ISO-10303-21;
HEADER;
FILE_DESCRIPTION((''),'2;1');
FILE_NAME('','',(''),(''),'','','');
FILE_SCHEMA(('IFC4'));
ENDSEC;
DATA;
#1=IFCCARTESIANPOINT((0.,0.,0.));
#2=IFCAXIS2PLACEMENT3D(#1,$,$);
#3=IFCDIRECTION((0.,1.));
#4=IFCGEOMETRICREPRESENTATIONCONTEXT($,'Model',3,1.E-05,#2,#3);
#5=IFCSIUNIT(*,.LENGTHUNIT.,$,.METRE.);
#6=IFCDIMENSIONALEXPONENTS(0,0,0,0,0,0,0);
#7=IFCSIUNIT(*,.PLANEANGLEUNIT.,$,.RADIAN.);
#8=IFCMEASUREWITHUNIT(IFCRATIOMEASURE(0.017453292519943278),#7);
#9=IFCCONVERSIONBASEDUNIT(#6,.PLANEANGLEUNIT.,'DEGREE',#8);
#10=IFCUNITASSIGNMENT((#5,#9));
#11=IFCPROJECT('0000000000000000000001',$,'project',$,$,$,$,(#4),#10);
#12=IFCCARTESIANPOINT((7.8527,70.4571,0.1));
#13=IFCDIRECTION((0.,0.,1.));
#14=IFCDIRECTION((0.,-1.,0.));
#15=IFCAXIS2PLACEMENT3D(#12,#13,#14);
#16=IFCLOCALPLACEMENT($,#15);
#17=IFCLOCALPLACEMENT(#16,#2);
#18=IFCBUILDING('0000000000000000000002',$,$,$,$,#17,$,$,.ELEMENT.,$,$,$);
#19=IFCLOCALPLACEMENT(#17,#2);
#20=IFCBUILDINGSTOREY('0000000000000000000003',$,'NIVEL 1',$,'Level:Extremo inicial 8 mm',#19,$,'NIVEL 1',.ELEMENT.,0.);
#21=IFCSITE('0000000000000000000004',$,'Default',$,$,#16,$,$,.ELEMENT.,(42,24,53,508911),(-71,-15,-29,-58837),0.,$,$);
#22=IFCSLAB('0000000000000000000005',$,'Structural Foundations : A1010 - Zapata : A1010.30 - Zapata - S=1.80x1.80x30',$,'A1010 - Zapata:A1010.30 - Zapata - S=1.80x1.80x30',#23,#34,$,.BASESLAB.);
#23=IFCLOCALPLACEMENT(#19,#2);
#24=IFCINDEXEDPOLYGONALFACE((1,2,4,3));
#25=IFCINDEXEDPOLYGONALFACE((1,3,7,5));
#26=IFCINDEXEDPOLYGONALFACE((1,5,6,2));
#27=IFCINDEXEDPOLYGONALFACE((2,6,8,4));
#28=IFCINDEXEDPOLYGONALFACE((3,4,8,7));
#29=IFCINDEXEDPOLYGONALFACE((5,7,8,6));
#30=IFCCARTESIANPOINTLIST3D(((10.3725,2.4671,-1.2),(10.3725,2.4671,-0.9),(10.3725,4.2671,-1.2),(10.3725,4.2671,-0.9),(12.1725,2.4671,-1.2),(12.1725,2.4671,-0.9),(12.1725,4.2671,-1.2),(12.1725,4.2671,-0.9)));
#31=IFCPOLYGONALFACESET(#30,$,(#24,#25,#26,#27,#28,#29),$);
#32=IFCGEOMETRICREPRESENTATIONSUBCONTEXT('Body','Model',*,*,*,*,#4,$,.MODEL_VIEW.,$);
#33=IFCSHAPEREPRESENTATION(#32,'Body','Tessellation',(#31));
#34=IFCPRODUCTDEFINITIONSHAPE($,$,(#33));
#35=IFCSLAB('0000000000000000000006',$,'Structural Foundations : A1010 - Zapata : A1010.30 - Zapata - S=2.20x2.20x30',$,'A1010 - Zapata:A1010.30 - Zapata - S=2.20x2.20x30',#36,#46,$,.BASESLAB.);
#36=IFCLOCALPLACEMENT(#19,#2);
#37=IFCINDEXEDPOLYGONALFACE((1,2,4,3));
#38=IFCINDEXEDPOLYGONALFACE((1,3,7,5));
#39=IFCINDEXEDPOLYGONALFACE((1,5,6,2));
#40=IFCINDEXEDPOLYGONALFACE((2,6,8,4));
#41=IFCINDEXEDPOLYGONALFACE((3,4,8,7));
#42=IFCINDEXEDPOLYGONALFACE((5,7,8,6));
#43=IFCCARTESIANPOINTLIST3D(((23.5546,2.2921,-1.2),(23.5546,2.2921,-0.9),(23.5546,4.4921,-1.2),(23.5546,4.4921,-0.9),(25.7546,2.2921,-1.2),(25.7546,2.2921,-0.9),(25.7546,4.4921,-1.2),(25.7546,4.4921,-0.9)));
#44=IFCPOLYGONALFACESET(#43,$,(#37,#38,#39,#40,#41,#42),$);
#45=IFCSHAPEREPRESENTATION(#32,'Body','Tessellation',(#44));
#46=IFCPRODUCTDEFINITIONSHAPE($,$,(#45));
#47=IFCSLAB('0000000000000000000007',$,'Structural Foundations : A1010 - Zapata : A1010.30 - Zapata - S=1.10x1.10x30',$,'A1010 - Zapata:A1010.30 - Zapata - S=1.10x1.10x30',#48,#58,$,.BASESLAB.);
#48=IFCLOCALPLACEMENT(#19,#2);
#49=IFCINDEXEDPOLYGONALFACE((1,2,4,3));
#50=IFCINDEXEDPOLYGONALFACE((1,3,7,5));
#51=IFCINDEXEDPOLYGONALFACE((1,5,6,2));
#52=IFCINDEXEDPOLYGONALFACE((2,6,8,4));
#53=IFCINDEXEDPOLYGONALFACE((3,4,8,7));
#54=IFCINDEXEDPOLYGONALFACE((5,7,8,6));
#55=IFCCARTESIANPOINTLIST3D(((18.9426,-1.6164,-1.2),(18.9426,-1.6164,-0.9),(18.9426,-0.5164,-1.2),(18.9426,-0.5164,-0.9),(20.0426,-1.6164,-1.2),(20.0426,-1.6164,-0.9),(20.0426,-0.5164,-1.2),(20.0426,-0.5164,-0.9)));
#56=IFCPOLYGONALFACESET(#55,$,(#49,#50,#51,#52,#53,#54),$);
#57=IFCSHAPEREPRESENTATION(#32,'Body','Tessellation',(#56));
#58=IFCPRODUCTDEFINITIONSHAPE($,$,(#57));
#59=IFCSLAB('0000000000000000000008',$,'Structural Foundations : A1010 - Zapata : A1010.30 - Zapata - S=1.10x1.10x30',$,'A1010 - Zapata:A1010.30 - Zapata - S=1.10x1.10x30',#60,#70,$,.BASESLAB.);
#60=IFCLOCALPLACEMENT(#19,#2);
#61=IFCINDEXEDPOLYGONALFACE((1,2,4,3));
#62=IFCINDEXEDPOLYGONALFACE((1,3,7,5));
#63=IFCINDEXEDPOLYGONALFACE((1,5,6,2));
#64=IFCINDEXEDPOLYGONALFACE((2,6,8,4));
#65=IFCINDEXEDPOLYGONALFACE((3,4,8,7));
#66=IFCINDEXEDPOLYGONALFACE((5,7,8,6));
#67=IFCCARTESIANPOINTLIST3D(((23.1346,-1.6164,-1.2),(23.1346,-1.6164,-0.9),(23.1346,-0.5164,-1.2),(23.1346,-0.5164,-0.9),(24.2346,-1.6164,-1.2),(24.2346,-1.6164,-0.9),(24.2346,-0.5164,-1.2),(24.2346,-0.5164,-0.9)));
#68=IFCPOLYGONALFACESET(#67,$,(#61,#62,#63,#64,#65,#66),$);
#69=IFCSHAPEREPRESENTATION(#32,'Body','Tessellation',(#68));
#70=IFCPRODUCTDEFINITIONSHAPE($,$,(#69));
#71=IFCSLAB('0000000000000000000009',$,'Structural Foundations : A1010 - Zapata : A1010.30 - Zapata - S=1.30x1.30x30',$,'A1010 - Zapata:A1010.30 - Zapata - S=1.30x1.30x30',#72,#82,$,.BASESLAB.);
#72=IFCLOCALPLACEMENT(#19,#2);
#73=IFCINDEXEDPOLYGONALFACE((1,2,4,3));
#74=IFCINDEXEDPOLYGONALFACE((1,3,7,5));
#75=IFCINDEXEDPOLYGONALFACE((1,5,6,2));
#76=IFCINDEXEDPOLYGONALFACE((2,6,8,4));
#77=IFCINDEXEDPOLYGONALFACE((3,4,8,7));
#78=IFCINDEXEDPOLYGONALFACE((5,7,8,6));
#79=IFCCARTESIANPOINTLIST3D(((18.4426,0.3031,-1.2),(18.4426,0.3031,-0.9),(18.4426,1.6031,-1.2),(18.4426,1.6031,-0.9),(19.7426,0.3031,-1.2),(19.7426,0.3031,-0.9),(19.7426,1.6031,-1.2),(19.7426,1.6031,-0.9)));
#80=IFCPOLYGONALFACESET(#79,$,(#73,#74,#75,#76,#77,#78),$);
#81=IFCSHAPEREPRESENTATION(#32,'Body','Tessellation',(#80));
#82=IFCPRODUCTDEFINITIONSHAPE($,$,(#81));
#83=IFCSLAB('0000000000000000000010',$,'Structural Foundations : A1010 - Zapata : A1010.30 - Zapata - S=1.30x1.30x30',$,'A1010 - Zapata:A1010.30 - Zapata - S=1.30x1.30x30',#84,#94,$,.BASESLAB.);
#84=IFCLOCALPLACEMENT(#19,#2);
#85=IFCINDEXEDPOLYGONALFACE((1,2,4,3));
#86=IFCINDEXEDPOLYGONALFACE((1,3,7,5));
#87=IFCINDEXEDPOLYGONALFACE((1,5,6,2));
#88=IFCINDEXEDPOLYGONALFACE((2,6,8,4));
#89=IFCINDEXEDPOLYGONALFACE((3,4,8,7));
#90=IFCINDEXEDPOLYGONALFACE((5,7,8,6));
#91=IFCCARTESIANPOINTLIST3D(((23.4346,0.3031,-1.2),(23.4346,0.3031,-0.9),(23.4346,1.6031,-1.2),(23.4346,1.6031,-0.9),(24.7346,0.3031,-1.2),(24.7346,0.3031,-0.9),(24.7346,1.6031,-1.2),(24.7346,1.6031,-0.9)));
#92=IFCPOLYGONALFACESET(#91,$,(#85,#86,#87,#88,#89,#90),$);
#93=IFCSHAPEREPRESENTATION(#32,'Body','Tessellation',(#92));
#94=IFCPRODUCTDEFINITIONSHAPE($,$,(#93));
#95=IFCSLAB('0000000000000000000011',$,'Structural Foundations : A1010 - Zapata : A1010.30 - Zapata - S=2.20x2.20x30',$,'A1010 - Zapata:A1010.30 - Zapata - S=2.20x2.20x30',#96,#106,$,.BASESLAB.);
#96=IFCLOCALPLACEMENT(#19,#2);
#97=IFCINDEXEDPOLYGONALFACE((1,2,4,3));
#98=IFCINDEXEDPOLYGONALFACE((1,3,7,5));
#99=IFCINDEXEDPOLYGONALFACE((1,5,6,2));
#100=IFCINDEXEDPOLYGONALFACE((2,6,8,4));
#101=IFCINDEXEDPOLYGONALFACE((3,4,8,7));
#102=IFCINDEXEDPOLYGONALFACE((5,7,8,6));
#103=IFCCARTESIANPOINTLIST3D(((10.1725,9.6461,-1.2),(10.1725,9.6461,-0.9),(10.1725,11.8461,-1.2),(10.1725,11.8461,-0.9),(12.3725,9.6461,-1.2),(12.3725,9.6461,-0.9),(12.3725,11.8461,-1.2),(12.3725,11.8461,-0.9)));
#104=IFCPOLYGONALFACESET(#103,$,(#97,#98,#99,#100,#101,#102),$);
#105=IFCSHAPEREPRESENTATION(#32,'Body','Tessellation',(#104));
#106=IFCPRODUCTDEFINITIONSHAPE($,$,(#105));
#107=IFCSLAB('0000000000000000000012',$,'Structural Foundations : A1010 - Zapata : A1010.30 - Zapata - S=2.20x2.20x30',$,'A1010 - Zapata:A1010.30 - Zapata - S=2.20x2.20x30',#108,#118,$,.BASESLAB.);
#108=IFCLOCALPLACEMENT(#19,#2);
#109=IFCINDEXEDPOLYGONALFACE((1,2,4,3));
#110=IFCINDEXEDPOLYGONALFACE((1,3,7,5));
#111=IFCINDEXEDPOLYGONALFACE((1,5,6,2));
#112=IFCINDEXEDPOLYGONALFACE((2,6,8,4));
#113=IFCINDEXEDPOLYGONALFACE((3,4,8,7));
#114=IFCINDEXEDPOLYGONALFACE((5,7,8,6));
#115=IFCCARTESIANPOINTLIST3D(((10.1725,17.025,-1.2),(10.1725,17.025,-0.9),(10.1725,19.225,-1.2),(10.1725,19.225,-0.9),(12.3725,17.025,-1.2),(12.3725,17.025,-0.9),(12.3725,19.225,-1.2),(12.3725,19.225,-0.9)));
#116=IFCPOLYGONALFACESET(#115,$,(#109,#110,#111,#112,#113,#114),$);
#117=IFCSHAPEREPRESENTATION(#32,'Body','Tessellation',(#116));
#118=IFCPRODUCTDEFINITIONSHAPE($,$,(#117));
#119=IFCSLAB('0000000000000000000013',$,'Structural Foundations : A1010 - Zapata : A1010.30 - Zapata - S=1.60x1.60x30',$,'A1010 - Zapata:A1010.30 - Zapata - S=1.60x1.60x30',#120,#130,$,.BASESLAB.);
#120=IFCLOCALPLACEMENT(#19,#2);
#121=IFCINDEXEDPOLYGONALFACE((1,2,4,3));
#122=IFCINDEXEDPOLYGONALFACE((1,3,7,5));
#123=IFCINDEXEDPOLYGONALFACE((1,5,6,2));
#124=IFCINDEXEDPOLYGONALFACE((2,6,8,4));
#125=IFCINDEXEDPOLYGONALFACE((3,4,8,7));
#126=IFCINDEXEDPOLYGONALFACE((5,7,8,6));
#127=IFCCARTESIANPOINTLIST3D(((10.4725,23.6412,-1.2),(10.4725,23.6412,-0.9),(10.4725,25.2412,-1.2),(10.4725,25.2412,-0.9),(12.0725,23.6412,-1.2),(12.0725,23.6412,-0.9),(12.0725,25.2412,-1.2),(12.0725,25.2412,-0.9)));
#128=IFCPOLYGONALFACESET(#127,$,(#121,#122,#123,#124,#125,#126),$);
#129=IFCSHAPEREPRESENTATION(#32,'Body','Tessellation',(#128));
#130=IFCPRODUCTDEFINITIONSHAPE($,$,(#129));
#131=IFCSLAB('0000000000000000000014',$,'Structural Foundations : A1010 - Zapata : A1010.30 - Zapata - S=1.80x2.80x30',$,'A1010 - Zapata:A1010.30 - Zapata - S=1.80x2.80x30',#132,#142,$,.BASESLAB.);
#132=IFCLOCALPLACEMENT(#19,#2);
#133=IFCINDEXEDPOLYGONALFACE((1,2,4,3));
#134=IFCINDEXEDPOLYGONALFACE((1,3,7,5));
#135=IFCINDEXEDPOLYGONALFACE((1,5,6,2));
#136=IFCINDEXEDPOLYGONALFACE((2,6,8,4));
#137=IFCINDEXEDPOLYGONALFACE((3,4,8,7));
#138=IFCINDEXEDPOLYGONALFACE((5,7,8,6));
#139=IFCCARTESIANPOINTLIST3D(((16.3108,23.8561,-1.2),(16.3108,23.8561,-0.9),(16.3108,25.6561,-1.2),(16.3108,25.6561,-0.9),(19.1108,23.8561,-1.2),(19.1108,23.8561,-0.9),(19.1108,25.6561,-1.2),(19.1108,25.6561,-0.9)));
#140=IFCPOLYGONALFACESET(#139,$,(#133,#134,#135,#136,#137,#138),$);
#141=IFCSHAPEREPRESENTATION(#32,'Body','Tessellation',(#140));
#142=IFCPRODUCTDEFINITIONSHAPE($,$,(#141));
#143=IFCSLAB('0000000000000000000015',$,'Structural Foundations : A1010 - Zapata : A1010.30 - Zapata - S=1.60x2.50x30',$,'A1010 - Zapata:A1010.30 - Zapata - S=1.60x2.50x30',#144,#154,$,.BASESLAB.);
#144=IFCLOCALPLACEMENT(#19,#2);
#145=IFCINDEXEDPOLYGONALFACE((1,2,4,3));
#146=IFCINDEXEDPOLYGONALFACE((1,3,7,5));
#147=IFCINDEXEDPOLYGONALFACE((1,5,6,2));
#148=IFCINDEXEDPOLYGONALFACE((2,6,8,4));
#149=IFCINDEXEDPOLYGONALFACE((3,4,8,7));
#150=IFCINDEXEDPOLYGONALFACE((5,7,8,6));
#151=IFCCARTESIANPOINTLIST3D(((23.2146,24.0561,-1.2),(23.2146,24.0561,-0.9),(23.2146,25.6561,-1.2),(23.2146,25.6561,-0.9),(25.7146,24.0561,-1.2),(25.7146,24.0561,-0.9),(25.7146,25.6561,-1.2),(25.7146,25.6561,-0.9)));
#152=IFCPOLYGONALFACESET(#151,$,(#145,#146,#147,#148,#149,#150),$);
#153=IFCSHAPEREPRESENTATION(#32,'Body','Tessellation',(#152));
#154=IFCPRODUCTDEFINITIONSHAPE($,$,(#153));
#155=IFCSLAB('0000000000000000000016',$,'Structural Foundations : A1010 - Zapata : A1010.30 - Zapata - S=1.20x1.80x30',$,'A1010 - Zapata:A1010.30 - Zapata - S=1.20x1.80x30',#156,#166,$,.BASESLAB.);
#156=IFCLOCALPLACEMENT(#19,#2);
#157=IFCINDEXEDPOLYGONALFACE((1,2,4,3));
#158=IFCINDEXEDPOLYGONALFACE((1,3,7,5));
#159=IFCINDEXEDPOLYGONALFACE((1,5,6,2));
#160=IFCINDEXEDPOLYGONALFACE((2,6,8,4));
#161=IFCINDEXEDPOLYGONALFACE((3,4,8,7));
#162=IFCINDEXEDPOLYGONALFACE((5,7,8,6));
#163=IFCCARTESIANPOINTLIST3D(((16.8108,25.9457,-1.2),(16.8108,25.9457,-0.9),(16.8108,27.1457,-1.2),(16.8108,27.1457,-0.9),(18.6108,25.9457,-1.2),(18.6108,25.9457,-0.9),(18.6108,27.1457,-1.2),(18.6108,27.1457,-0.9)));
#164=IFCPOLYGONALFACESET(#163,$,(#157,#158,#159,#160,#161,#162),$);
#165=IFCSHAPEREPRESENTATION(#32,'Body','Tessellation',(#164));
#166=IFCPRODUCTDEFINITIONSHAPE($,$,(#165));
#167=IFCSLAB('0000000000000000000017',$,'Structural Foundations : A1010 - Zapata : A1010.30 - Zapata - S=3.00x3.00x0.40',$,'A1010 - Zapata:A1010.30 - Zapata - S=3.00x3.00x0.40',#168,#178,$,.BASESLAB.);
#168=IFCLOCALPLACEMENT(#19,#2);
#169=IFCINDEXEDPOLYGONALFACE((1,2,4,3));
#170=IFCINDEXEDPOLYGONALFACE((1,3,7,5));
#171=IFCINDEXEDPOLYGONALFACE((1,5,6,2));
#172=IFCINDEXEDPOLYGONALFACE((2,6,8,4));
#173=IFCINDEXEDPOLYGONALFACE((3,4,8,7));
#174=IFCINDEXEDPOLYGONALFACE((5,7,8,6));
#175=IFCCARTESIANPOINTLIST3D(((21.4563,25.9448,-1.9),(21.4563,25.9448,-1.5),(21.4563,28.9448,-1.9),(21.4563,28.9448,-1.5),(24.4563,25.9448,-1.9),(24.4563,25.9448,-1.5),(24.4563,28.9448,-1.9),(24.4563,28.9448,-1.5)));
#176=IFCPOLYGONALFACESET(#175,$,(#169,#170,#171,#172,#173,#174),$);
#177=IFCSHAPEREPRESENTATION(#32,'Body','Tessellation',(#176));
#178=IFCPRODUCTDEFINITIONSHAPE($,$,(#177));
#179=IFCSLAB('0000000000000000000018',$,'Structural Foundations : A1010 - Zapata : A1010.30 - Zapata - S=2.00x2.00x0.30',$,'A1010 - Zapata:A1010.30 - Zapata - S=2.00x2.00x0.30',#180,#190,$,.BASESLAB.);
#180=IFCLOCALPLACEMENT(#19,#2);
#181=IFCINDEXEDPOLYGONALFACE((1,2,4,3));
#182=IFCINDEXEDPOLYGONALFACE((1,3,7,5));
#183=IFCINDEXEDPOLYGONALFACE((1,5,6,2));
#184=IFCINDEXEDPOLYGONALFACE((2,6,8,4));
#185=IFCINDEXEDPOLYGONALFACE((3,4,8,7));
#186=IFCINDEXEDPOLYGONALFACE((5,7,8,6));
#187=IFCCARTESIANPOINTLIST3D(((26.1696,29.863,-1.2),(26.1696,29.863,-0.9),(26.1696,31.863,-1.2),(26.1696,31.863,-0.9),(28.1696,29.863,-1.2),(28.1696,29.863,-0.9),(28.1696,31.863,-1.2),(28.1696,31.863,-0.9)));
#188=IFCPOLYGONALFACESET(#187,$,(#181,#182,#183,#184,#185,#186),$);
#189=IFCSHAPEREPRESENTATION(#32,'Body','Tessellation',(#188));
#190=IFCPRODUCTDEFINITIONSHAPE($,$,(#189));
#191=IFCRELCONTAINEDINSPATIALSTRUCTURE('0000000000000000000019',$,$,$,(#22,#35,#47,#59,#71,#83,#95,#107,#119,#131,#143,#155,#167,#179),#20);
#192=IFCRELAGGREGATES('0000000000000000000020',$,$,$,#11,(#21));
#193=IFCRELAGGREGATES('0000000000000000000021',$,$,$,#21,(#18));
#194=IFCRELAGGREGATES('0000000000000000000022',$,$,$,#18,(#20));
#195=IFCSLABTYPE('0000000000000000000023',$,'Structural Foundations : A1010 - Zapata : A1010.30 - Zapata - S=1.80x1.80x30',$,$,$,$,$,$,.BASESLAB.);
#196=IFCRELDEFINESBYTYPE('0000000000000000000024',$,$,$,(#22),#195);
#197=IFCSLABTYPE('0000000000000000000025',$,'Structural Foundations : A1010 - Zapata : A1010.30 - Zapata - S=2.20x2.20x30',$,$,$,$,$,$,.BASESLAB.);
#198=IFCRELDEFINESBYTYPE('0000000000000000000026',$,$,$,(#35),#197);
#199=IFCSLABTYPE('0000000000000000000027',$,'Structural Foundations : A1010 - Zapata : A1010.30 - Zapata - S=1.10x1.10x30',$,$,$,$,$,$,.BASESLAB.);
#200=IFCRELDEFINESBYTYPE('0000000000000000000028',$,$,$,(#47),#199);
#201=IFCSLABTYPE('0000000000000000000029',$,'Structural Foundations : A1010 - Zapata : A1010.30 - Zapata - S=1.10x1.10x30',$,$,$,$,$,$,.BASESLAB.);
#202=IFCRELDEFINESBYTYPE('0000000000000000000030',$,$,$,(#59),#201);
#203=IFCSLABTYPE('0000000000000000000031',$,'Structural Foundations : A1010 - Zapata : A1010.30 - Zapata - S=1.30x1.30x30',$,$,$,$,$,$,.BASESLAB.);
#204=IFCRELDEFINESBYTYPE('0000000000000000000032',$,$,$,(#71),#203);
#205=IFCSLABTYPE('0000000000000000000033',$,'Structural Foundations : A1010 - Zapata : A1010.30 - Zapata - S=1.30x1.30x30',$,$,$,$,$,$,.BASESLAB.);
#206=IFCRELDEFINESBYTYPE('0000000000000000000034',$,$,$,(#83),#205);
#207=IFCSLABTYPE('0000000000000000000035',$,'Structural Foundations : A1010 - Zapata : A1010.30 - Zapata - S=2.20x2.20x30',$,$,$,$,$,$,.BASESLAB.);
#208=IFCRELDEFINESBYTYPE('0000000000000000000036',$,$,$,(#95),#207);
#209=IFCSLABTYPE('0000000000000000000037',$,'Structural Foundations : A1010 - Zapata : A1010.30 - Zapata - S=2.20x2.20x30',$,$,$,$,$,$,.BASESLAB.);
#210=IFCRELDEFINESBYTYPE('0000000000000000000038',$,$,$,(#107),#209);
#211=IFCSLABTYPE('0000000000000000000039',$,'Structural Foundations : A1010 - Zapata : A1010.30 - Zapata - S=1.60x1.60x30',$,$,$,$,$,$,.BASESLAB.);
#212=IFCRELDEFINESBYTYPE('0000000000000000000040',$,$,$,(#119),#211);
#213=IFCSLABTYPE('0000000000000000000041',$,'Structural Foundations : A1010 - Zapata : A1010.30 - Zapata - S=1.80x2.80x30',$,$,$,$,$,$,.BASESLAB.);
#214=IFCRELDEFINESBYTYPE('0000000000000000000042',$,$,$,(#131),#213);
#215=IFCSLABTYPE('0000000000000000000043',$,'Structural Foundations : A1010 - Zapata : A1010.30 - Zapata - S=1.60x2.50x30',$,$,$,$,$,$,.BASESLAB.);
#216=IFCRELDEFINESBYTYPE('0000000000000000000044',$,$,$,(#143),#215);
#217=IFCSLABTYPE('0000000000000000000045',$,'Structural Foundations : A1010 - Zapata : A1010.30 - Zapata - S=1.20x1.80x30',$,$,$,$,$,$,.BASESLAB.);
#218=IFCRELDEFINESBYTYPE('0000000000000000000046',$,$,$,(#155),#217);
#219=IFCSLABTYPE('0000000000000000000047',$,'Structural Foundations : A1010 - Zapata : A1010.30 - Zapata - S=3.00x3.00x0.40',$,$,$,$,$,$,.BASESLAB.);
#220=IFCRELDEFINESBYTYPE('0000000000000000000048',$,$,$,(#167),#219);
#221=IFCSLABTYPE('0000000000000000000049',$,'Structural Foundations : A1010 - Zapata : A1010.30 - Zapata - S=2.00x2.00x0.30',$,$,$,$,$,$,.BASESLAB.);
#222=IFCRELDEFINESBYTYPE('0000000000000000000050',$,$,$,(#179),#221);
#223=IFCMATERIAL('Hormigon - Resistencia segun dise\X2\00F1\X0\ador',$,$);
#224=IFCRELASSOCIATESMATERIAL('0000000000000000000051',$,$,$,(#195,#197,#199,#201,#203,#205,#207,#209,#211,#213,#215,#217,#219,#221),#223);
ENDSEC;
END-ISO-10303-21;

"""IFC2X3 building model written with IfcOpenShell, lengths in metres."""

from ifc_helpers import new_model, entity, si_unit, converted_unit, direction, frame, frame_2d, origin, origin_2d_with_axis, place, context, subcontext, project, spatial, rectangle, extrude, material, type_object, element, save


model = new_model("IFC2X3")

# Units and contexts
model_context = context("Model", 3, precision=1e-05, world=origin(), true_north=direction((0.0, 1.0)))
body_context = subcontext(model_context, "Body", "Model", "MODEL_VIEW")
ifc_project = project(units=[si_unit("LENGTHUNIT", "METRE"), converted_unit("PLANEANGLEUNIT", "DEGREE", entity("IfcRatioMeasure", 0.017453292519943278), si_unit("PLANEANGLEUNIT", "RADIAN"), dimensions=[0, 0, 0, 0, 0, 0, 0])], contexts=[model_context])

# Site, building, storey
site_placement = place(None, frame((7.8527, 70.4571, 0.1), z_axis=(0.0, 0.0, 1.0), x_axis=(0.0, -1.0, 0.0)))
site = spatial("IfcSite", under=ifc_project, at=site_placement, Name="Default", CompositionType="ELEMENT", RefLatitude=(42, 24, 53, 508911), RefLongitude=(-71, -15, -29, -58837), RefElevation=0.0)
building_placement = place(site_placement, origin())
building = spatial("IfcBuilding", under=site, at=building_placement, CompositionType="ELEMENT")
storey_placement = place(building_placement, origin())
storey = spatial("IfcBuildingStorey", under=building, at=storey_placement, Name="NIVEL 1", ObjectType="Level:Extremo inicial 8 mm", LongName="NIVEL 1", CompositionType="ELEMENT", Elevation=0.0)

# Slabs
ifc_material = material(Name="Hormigon - Resistencia segun diseñador")
slab_type_1 = type_object("IfcSlabType", Name="Structural Foundations : A1010 - Zapata : A1010.30 - Zapata - S=1.80x1.80x30", PredefinedType="BASESLAB", material=ifc_material)
slab_1_placement = place(storey_placement, origin())
element("IfcSlab", 1, at=slab_1_placement, inside=storey, type_object=slab_type_1, Name="Structural Foundations : A1010 - Zapata : A1010.30 - Zapata - S=1.80x1.80x30", ObjectType="A1010 - Zapata:A1010.30 - Zapata - S=1.80x1.80x30", PredefinedType="BASESLAB", context=body_context, shape_type="SweptSolid", body=[
    extrude(rectangle(XDim=1.8, YDim=1.8, at=frame_2d((0.0, 0.0), x_axis=(1.0, 0.0))), frame((11.2725, 3.3671, -1.2), z_axis=(0.0, 0.0, 1.0), x_axis=(-1.0, 0.0, 0.0)), (0.0, 0.0, 1.0), 0.3),
])
slab_type_2 = type_object("IfcSlabType", Name="Structural Foundations : A1010 - Zapata : A1010.30 - Zapata - S=2.20x2.20x30", PredefinedType="BASESLAB", material=ifc_material)
slab_2_placement = place(storey_placement, origin())
element("IfcSlab", 2, at=slab_2_placement, inside=storey, type_object=slab_type_2, Name="Structural Foundations : A1010 - Zapata : A1010.30 - Zapata - S=2.20x2.20x30", ObjectType="A1010 - Zapata:A1010.30 - Zapata - S=2.20x2.20x30", PredefinedType="BASESLAB", context=body_context, shape_type="SweptSolid", body=[
    extrude(rectangle(XDim=2.2, YDim=2.2, at=frame_2d((0.0, 0.0), x_axis=(1.0, 0.0))), frame((24.6546, 3.3921, -1.2), z_axis=(0.0, 0.0, 1.0), x_axis=(-1.0, 0.0, 0.0)), (0.0, 0.0, 1.0), 0.3),
])
slab_type_3 = type_object("IfcSlabType", Name="Structural Foundations : A1010 - Zapata : A1010.30 - Zapata - S=1.10x1.10x30", PredefinedType="BASESLAB", material=ifc_material)
slab_3_placement = place(storey_placement, origin())
element("IfcSlab", 3, at=slab_3_placement, inside=storey, type_object=slab_type_3, Name="Structural Foundations : A1010 - Zapata : A1010.30 - Zapata - S=1.10x1.10x30", ObjectType="A1010 - Zapata:A1010.30 - Zapata - S=1.10x1.10x30", PredefinedType="BASESLAB", context=body_context, shape_type="SweptSolid", body=[
    extrude(rectangle(XDim=1.1, YDim=1.1, at=frame_2d((0.0, 0.0), x_axis=(1.0, 0.0))), frame((19.4926, -1.0664, -1.2), z_axis=(0.0, 0.0, 1.0), x_axis=(-1.0, 0.0, 0.0)), (0.0, 0.0, 1.0), 0.3),
])
slab_type_4 = type_object("IfcSlabType", Name="Structural Foundations : A1010 - Zapata : A1010.30 - Zapata - S=1.10x1.10x30", PredefinedType="BASESLAB", material=ifc_material)
slab_4_placement = place(storey_placement, origin())
element("IfcSlab", 4, at=slab_4_placement, inside=storey, type_object=slab_type_4, Name="Structural Foundations : A1010 - Zapata : A1010.30 - Zapata - S=1.10x1.10x30", ObjectType="A1010 - Zapata:A1010.30 - Zapata - S=1.10x1.10x30", PredefinedType="BASESLAB", context=body_context, shape_type="SweptSolid", body=[
    extrude(rectangle(XDim=1.1, YDim=1.1, at=frame_2d((0.0, 0.0), x_axis=(1.0, 0.0))), frame((23.6846, -1.0664, -1.2), z_axis=(0.0, 0.0, 1.0), x_axis=(-1.0, 0.0, 0.0)), (0.0, 0.0, 1.0), 0.3),
])
slab_type_5 = type_object("IfcSlabType", Name="Structural Foundations : A1010 - Zapata : A1010.30 - Zapata - S=1.30x1.30x30", PredefinedType="BASESLAB", material=ifc_material)
slab_5_placement = place(storey_placement, origin())
element("IfcSlab", 5, at=slab_5_placement, inside=storey, type_object=slab_type_5, Name="Structural Foundations : A1010 - Zapata : A1010.30 - Zapata - S=1.30x1.30x30", ObjectType="A1010 - Zapata:A1010.30 - Zapata - S=1.30x1.30x30", PredefinedType="BASESLAB", context=body_context, shape_type="SweptSolid", body=[
    extrude(rectangle(XDim=1.3, YDim=1.3, at=frame_2d((0.0, 0.0), x_axis=(1.0, 0.0))), frame((19.0926, 0.9531, -1.2), z_axis=(0.0, 0.0, 1.0), x_axis=(-1.0, 0.0, 0.0)), (0.0, 0.0, 1.0), 0.3),
])
slab_type_6 = type_object("IfcSlabType", Name="Structural Foundations : A1010 - Zapata : A1010.30 - Zapata - S=1.30x1.30x30", PredefinedType="BASESLAB", material=ifc_material)
slab_6_placement = place(storey_placement, origin())
element("IfcSlab", 6, at=slab_6_placement, inside=storey, type_object=slab_type_6, Name="Structural Foundations : A1010 - Zapata : A1010.30 - Zapata - S=1.30x1.30x30", ObjectType="A1010 - Zapata:A1010.30 - Zapata - S=1.30x1.30x30", PredefinedType="BASESLAB", context=body_context, shape_type="SweptSolid", body=[
    extrude(rectangle(XDim=1.3, YDim=1.3, at=frame_2d((0.0, 0.0), x_axis=(1.0, 0.0))), frame((24.0846, 0.9531, -1.2), z_axis=(0.0, 0.0, 1.0), x_axis=(-1.0, 0.0, 0.0)), (0.0, 0.0, 1.0), 0.3),
])
slab_type_7 = type_object("IfcSlabType", Name="Structural Foundations : A1010 - Zapata : A1010.30 - Zapata - S=2.20x2.20x30", PredefinedType="BASESLAB", material=ifc_material)
slab_7_placement = place(storey_placement, origin())
element("IfcSlab", 7, at=slab_7_placement, inside=storey, type_object=slab_type_7, Name="Structural Foundations : A1010 - Zapata : A1010.30 - Zapata - S=2.20x2.20x30", ObjectType="A1010 - Zapata:A1010.30 - Zapata - S=2.20x2.20x30", PredefinedType="BASESLAB", context=body_context, shape_type="SweptSolid", body=[
    extrude(rectangle(XDim=2.2, YDim=2.2, at=frame_2d((0.0, 0.0), x_axis=(1.0, 0.0))), frame((11.2725, 10.7461, -1.2), z_axis=(0.0, 0.0, 1.0), x_axis=(-1.0, 0.0, 0.0)), (0.0, 0.0, 1.0), 0.3),
])
slab_type_8 = type_object("IfcSlabType", Name="Structural Foundations : A1010 - Zapata : A1010.30 - Zapata - S=2.20x2.20x30", PredefinedType="BASESLAB", material=ifc_material)
slab_8_placement = place(storey_placement, origin())
element("IfcSlab", 8, at=slab_8_placement, inside=storey, type_object=slab_type_8, Name="Structural Foundations : A1010 - Zapata : A1010.30 - Zapata - S=2.20x2.20x30", ObjectType="A1010 - Zapata:A1010.30 - Zapata - S=2.20x2.20x30", PredefinedType="BASESLAB", context=body_context, shape_type="SweptSolid", body=[
    extrude(rectangle(XDim=2.2, YDim=2.2, at=frame_2d((0.0, 0.0), x_axis=(1.0, 0.0))), frame((11.2725, 18.125, -1.2), z_axis=(0.0, 0.0, 1.0), x_axis=(-1.0, 0.0, 0.0)), (0.0, 0.0, 1.0), 0.3),
])
slab_type_9 = type_object("IfcSlabType", Name="Structural Foundations : A1010 - Zapata : A1010.30 - Zapata - S=1.60x1.60x30", PredefinedType="BASESLAB", material=ifc_material)
slab_9_placement = place(storey_placement, origin())
element("IfcSlab", 9, at=slab_9_placement, inside=storey, type_object=slab_type_9, Name="Structural Foundations : A1010 - Zapata : A1010.30 - Zapata - S=1.60x1.60x30", ObjectType="A1010 - Zapata:A1010.30 - Zapata - S=1.60x1.60x30", PredefinedType="BASESLAB", context=body_context, shape_type="SweptSolid", body=[
    extrude(rectangle(XDim=1.6, YDim=1.6, at=origin_2d_with_axis()), frame((11.2725, 24.4412, -1.2), z_axis=(0.0, 0.0, 1.0), x_axis=(-1.0, 0.0, 0.0)), (0.0, 0.0, 1.0), 0.3),
])
slab_type_10 = type_object("IfcSlabType", Name="Structural Foundations : A1010 - Zapata : A1010.30 - Zapata - S=1.80x2.80x30", PredefinedType="BASESLAB", material=ifc_material)
slab_10_placement = place(storey_placement, origin())
element("IfcSlab", 10, at=slab_10_placement, inside=storey, type_object=slab_type_10, Name="Structural Foundations : A1010 - Zapata : A1010.30 - Zapata - S=1.80x2.80x30", ObjectType="A1010 - Zapata:A1010.30 - Zapata - S=1.80x2.80x30", PredefinedType="BASESLAB", context=body_context, shape_type="SweptSolid", body=[
    extrude(rectangle(XDim=1.8, YDim=2.8, at=frame_2d((0.0, 0.0), x_axis=(1.0, 0.0))), frame((17.7108, 24.7561, -1.2), z_axis=(0.0, 0.0, 1.0), x_axis=(0.0, -1.0, 0.0)), (0.0, 0.0, 1.0), 0.3),
])
slab_type_11 = type_object("IfcSlabType", Name="Structural Foundations : A1010 - Zapata : A1010.30 - Zapata - S=1.60x2.50x30", PredefinedType="BASESLAB", material=ifc_material)
slab_11_placement = place(storey_placement, origin())
element("IfcSlab", 11, at=slab_11_placement, inside=storey, type_object=slab_type_11, Name="Structural Foundations : A1010 - Zapata : A1010.30 - Zapata - S=1.60x2.50x30", ObjectType="A1010 - Zapata:A1010.30 - Zapata - S=1.60x2.50x30", PredefinedType="BASESLAB", context=body_context, shape_type="SweptSolid", body=[
    extrude(rectangle(XDim=1.6, YDim=2.5, at=frame_2d((0.0, 0.0), x_axis=(1.0, 0.0))), frame((24.4646, 24.8561, -1.2), z_axis=(0.0, 0.0, 1.0), x_axis=(0.0, -1.0, 0.0)), (0.0, 0.0, 1.0), 0.3),
])
slab_type_12 = type_object("IfcSlabType", Name="Structural Foundations : A1010 - Zapata : A1010.30 - Zapata - S=1.20x1.80x30", PredefinedType="BASESLAB", material=ifc_material)
slab_12_placement = place(storey_placement, origin())
element("IfcSlab", 12, at=slab_12_placement, inside=storey, type_object=slab_type_12, Name="Structural Foundations : A1010 - Zapata : A1010.30 - Zapata - S=1.20x1.80x30", ObjectType="A1010 - Zapata:A1010.30 - Zapata - S=1.20x1.80x30", PredefinedType="BASESLAB", context=body_context, shape_type="SweptSolid", body=[
    extrude(rectangle(XDim=1.2, YDim=1.8, at=origin_2d_with_axis()), frame((17.7108, 26.5457, -1.2), z_axis=(0.0, 0.0, 1.0), x_axis=(0.0, -1.0, 0.0)), (0.0, 0.0, 1.0), 0.3),
])
slab_type_13 = type_object("IfcSlabType", Name="Structural Foundations : A1010 - Zapata : A1010.30 - Zapata - S=3.00x3.00x0.40", PredefinedType="BASESLAB", material=ifc_material)
slab_13_placement = place(storey_placement, origin())
element("IfcSlab", 13, at=slab_13_placement, inside=storey, type_object=slab_type_13, Name="Structural Foundations : A1010 - Zapata : A1010.30 - Zapata - S=3.00x3.00x0.40", ObjectType="A1010 - Zapata:A1010.30 - Zapata - S=3.00x3.00x0.40", PredefinedType="BASESLAB", context=body_context, shape_type="SweptSolid", body=[
    extrude(rectangle(XDim=3.0, YDim=3.0, at=origin_2d_with_axis()), frame((22.9563, 27.4448, -1.9), z_axis=(0.0, 0.0, 1.0), x_axis=(0.0, -1.0, 0.0)), (0.0, 0.0, 1.0), 0.4),
])
slab_type_14 = type_object("IfcSlabType", Name="Structural Foundations : A1010 - Zapata : A1010.30 - Zapata - S=2.00x2.00x0.30", PredefinedType="BASESLAB", material=ifc_material)
slab_14_placement = place(storey_placement, origin())
element("IfcSlab", 14, at=slab_14_placement, inside=storey, type_object=slab_type_14, Name="Structural Foundations : A1010 - Zapata : A1010.30 - Zapata - S=2.00x2.00x0.30", ObjectType="A1010 - Zapata:A1010.30 - Zapata - S=2.00x2.00x0.30", PredefinedType="BASESLAB", context=body_context, shape_type="SweptSolid", body=[
    extrude(rectangle(XDim=2.0, YDim=2.0, at=origin_2d_with_axis()), frame((27.1696, 30.863, -1.2), z_axis=(0.0, 0.0, 1.0), x_axis=(0.0, -1.0, 0.0)), (0.0, 0.0, 1.0), 0.3),
])

save(model, "model.ifc")
